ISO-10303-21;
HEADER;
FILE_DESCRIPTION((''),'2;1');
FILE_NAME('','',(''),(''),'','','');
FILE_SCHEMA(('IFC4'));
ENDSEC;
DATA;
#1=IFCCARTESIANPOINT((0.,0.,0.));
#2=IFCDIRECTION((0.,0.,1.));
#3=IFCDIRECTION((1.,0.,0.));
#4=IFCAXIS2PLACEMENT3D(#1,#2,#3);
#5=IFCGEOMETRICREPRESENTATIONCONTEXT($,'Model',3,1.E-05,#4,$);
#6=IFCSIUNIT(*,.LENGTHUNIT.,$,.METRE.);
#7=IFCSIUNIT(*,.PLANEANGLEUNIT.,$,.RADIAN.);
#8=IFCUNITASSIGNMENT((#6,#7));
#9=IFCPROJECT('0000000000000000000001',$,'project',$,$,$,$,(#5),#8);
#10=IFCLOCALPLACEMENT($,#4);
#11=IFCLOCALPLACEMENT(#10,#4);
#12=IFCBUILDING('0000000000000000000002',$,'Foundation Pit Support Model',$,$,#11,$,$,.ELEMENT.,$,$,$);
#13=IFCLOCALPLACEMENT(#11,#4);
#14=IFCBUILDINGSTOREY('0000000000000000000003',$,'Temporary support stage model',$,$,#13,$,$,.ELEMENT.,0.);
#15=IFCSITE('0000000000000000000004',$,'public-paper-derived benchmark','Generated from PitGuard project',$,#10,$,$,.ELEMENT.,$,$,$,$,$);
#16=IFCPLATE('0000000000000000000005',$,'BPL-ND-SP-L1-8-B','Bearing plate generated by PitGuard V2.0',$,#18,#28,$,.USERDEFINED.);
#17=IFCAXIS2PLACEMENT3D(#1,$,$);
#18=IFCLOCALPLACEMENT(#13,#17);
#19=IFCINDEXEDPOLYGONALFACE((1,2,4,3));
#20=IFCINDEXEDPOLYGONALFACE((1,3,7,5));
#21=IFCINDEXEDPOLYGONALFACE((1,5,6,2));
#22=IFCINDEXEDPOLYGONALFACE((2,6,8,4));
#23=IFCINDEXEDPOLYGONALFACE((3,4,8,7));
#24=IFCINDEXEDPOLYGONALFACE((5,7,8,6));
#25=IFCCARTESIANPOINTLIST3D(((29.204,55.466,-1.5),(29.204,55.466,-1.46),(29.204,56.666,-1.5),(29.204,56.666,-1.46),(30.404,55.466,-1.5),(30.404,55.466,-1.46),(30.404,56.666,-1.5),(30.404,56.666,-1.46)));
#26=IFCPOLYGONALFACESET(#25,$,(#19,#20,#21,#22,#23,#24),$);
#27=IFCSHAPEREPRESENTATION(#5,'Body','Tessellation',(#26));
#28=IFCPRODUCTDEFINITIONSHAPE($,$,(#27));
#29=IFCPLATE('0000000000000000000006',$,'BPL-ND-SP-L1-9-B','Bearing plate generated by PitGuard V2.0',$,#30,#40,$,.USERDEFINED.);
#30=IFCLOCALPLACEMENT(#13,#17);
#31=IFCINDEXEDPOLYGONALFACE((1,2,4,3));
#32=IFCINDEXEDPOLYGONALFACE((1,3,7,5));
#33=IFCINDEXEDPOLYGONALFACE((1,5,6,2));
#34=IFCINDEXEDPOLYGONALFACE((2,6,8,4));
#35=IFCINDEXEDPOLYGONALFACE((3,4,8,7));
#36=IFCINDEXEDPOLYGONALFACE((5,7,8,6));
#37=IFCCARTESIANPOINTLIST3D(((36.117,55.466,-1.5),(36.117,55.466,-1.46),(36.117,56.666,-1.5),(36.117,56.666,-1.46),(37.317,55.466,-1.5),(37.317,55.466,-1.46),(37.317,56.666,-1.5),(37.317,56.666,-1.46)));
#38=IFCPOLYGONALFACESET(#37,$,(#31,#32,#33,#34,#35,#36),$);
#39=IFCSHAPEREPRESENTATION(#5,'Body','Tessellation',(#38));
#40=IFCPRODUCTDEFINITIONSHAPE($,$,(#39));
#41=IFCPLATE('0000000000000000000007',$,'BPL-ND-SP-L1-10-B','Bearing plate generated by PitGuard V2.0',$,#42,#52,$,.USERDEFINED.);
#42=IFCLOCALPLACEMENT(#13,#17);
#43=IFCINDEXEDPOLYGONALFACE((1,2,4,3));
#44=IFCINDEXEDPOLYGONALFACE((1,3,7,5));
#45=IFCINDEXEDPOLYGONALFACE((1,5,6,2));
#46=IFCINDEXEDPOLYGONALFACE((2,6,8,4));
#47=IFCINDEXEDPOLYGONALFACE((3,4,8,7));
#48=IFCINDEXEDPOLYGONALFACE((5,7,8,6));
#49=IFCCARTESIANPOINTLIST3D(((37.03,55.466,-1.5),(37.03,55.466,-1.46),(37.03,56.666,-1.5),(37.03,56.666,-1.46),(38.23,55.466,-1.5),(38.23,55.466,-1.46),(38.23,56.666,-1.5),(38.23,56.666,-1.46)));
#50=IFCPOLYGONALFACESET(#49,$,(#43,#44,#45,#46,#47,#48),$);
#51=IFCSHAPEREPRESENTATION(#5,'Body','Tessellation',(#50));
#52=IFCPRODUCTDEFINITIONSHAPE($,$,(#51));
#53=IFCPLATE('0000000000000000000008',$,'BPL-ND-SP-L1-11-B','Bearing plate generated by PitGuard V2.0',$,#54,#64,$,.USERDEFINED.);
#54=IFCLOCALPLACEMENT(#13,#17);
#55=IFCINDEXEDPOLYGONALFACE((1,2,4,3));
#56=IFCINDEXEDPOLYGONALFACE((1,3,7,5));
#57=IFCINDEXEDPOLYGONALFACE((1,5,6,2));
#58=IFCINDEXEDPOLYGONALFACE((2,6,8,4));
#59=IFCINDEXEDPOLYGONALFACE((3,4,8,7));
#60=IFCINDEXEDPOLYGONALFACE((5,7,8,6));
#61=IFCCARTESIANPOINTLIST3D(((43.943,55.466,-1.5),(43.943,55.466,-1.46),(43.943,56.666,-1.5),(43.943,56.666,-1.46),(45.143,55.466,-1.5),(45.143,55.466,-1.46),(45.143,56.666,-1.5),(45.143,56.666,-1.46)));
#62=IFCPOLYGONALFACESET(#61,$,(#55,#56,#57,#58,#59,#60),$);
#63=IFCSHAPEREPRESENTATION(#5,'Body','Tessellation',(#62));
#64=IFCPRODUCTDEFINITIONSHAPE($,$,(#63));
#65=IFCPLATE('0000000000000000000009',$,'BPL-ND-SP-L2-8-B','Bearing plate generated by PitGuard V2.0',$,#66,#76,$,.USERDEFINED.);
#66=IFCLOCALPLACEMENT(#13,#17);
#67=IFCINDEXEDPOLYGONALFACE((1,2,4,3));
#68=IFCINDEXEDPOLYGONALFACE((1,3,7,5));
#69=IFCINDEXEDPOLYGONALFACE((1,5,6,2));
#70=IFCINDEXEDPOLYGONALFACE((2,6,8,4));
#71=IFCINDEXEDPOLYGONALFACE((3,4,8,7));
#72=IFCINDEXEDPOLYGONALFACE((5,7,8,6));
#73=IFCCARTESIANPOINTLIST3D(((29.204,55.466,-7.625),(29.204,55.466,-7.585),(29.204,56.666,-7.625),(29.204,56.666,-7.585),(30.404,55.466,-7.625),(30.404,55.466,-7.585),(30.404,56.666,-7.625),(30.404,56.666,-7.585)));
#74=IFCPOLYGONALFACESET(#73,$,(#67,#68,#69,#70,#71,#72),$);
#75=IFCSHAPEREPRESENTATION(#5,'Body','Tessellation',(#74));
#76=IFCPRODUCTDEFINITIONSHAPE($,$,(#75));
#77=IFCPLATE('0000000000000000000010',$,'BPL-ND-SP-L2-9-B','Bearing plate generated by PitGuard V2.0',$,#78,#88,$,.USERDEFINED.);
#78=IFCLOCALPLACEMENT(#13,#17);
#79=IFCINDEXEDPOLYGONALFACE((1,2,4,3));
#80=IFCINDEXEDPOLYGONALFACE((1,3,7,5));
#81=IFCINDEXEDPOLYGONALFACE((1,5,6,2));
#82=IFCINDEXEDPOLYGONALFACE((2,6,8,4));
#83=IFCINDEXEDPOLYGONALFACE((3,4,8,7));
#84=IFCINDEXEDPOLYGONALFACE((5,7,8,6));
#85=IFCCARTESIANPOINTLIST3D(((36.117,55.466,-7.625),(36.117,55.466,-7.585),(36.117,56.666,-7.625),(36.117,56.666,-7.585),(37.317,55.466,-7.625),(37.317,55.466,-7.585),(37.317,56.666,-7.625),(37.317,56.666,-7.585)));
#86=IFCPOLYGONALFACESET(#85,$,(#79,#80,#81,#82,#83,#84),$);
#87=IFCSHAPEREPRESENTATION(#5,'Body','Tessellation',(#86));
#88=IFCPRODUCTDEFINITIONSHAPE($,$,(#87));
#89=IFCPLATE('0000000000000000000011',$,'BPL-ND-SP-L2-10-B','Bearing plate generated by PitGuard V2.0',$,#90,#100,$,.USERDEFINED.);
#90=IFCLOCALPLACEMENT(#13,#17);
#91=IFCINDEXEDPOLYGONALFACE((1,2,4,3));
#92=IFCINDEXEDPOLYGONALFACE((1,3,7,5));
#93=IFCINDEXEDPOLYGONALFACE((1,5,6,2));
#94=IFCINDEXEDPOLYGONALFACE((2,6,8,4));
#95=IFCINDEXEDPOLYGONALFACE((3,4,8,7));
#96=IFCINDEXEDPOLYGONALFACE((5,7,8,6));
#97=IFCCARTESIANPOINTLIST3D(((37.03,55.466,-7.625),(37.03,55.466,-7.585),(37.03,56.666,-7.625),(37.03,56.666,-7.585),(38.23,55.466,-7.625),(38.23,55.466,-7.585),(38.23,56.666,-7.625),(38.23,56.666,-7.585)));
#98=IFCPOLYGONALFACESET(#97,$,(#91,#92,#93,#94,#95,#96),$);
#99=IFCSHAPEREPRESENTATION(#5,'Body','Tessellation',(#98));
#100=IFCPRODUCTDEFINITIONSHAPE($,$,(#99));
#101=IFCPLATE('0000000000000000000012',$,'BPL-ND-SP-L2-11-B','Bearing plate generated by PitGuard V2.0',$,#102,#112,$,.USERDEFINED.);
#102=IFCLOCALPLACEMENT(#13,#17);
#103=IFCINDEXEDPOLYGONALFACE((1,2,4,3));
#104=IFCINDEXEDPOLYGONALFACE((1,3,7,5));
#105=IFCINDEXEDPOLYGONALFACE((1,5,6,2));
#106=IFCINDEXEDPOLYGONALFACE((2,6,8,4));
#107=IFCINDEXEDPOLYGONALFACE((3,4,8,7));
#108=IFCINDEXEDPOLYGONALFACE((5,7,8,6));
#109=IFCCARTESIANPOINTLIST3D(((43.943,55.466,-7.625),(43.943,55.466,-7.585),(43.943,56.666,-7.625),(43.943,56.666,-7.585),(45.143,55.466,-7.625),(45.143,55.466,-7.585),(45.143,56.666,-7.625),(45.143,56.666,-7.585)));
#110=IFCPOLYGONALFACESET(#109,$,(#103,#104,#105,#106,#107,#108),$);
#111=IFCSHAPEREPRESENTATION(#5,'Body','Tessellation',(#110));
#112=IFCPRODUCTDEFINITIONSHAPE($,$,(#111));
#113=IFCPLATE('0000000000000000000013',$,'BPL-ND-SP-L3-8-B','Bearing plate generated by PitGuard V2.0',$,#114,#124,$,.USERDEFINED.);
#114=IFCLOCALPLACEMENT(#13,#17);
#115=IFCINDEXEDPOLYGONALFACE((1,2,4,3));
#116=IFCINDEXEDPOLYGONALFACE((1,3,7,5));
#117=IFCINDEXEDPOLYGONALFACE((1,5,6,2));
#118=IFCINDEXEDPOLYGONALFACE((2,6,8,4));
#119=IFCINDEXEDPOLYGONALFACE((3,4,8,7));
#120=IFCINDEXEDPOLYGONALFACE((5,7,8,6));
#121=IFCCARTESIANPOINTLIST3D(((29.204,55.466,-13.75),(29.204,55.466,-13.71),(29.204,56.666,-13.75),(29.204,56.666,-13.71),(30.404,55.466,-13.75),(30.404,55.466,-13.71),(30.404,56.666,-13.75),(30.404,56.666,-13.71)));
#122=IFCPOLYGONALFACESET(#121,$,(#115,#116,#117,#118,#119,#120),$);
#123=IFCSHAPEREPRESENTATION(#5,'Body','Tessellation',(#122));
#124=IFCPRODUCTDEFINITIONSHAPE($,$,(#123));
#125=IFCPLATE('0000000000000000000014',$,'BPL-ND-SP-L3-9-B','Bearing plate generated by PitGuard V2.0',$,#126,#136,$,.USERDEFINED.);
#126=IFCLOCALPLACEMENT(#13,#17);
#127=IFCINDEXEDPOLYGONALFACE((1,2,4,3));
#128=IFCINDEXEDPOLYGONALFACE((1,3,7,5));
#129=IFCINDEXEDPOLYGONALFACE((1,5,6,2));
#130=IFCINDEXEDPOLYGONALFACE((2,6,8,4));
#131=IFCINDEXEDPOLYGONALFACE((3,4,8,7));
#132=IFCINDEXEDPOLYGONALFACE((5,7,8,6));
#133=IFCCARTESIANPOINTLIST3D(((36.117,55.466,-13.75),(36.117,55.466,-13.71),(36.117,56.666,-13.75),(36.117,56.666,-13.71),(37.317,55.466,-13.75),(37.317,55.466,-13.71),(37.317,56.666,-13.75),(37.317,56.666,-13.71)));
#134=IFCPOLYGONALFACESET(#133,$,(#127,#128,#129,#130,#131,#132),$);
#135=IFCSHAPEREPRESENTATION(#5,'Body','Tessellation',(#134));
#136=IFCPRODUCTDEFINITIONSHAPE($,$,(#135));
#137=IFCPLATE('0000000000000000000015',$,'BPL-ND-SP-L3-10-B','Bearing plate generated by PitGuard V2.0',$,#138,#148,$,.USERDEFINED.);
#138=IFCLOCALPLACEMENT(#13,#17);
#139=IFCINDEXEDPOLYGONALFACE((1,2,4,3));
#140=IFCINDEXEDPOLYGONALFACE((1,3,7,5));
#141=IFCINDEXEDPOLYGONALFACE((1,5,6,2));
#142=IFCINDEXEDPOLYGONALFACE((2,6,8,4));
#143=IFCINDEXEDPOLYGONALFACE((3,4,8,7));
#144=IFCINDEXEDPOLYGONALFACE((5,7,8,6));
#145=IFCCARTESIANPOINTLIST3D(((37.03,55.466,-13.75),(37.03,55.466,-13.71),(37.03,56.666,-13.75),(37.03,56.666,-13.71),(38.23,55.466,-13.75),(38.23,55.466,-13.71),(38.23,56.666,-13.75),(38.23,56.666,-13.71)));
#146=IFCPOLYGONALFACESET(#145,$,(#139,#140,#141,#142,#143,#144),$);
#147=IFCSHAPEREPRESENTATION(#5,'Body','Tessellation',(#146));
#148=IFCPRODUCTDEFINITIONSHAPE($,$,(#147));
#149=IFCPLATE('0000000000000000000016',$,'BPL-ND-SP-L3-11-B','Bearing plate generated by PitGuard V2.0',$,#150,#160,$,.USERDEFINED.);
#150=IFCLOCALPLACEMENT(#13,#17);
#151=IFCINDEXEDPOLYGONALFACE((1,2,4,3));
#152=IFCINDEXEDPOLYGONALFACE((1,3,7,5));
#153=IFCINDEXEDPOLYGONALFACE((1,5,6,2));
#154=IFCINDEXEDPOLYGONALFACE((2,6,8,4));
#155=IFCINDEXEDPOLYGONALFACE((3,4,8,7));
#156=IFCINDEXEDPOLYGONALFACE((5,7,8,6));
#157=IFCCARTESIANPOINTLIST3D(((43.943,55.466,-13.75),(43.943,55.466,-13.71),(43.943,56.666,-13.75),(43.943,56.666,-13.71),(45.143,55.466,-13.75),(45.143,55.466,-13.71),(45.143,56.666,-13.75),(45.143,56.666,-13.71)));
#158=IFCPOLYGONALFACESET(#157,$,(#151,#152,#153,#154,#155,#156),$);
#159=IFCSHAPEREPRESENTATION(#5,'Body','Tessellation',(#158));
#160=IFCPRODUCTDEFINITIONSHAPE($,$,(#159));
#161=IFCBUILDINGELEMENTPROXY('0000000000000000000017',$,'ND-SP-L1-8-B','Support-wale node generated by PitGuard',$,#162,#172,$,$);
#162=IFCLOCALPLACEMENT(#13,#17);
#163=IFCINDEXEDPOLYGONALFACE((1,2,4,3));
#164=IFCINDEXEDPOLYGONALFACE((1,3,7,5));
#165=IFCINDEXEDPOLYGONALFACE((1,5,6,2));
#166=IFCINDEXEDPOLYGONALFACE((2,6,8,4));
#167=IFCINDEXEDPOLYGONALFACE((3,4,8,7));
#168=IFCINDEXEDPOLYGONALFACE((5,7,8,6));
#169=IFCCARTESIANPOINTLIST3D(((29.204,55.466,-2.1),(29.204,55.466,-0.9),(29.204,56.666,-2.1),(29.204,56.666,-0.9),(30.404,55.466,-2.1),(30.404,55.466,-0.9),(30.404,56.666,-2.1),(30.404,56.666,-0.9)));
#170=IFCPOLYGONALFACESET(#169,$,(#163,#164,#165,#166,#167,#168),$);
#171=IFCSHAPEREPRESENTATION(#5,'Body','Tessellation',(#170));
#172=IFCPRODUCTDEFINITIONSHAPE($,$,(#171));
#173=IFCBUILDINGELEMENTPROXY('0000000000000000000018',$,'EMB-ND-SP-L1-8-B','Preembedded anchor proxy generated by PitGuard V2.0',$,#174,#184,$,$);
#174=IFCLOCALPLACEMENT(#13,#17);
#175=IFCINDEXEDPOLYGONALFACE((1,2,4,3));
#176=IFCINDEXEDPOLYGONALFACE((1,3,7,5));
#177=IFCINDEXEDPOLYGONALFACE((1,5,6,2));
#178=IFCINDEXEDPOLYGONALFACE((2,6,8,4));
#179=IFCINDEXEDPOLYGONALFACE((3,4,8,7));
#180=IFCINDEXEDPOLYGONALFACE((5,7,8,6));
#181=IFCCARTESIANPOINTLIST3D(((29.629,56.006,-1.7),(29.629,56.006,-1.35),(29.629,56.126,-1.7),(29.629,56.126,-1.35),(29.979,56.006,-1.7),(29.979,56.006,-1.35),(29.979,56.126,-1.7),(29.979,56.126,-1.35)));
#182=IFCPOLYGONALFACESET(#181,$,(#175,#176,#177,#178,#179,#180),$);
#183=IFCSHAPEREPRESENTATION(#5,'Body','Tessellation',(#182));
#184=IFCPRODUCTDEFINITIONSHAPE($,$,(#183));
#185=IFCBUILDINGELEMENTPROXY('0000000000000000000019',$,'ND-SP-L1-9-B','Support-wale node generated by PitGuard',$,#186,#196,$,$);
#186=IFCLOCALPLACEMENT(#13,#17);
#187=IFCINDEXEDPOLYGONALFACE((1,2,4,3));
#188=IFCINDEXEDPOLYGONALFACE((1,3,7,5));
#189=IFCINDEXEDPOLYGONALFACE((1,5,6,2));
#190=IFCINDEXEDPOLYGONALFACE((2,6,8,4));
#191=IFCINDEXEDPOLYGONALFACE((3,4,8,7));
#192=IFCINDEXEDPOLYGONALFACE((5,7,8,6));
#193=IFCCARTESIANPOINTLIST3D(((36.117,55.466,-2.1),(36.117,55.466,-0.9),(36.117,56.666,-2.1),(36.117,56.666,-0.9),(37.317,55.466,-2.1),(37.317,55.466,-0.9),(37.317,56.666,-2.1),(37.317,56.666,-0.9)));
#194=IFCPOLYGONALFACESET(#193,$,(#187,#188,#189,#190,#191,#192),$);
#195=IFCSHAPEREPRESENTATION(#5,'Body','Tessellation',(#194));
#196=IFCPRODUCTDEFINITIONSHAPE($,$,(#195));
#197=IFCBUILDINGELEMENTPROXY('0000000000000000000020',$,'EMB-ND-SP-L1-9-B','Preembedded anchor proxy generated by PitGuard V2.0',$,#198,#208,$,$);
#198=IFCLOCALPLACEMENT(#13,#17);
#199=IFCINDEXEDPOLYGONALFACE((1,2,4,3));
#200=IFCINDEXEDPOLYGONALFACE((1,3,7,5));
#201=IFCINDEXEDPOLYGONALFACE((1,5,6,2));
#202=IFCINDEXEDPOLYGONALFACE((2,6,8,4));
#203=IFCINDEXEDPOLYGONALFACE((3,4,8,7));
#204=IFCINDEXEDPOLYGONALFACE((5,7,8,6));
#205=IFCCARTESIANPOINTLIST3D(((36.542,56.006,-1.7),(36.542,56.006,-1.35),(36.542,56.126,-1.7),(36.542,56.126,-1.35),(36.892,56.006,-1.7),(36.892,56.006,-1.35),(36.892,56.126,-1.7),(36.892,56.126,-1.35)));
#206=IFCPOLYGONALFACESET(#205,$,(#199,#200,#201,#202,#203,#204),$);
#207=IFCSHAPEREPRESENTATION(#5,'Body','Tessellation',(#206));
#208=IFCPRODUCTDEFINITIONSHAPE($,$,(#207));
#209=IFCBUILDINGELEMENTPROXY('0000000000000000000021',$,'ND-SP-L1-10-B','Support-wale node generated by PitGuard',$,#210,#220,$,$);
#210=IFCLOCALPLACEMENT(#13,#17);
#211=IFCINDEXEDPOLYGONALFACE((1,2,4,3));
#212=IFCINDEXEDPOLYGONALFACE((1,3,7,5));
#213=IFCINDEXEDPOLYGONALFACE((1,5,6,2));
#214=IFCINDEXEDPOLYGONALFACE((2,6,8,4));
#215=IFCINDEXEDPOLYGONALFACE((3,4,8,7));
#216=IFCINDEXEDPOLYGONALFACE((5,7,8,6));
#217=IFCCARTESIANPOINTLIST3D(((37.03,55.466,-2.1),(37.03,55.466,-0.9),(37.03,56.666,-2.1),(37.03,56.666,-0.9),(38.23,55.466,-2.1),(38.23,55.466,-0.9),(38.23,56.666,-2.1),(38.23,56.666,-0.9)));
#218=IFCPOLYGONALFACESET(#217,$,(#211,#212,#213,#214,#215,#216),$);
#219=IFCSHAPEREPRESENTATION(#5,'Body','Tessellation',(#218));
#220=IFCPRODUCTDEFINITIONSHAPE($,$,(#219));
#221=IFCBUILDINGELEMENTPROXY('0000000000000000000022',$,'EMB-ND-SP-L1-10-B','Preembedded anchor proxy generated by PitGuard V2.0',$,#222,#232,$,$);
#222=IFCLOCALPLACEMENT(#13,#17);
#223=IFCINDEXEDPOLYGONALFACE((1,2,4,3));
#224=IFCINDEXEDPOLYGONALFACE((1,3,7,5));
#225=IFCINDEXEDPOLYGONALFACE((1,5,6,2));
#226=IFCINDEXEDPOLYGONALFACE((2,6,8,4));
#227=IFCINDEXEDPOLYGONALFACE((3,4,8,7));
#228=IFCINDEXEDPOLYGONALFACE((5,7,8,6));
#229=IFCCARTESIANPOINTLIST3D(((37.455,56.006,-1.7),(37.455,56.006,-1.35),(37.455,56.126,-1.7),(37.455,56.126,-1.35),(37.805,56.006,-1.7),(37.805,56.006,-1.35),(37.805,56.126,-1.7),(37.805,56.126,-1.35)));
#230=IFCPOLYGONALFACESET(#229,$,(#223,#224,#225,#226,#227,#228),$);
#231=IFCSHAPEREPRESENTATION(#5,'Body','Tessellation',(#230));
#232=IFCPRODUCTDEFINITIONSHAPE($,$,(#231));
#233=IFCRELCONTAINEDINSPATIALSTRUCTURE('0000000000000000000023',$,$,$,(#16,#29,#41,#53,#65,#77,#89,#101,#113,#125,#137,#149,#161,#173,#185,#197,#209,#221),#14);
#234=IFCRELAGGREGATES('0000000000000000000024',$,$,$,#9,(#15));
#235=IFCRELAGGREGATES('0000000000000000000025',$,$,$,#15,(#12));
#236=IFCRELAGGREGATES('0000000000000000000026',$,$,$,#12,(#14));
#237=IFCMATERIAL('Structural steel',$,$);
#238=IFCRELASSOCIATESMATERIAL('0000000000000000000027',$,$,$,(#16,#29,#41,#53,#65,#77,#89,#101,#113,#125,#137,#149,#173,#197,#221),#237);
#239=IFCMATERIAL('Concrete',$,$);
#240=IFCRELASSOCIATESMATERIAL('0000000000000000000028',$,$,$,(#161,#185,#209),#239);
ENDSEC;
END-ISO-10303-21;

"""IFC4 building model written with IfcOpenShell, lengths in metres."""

from ifc_helpers import new_model, si_unit, frame, origin_with_axes, origin_2d, place, context, project, spatial, rectangle, extrude, material, element, save


model = new_model("IFC4")

# Units and contexts
model_context = context("Model", 3, precision=1e-05, world=origin_with_axes())
ifc_project = project(units=[si_unit("LENGTHUNIT", "METRE"), si_unit("PLANEANGLEUNIT", "RADIAN")], contexts=[model_context])

# Site, building, storey
site_placement = place(None, origin_with_axes())
site = spatial("IfcSite", under=ifc_project, at=site_placement, Name="public-paper-derived benchmark", Description="Generated from PitGuard project", CompositionType="ELEMENT")
building_placement = place(site_placement, origin_with_axes())
building = spatial("IfcBuilding", under=site, at=building_placement, Name="Foundation Pit Support Model", CompositionType="ELEMENT")
storey_placement = place(building_placement, origin_with_axes())
storey = spatial("IfcBuildingStorey", under=building, at=storey_placement, Name="Temporary support stage model", CompositionType="ELEMENT", Elevation=0.0)

# Plates
ifc_material_1 = material(Name="Structural steel")
for number, where, z_axis, x_axis, name in (
    (1, (29.804, 56.066, -1.5), (0.0, 0.0, 1.0), (1.0, 0.0, 0.0), "BPL-ND-SP-L1-8-B"),
    (2, (36.717, 56.066, -1.5), (0.0, 0.0, 1.0), (1.0, 0.0, 0.0), "BPL-ND-SP-L1-9-B"),
    (3, (37.63, 56.066, -1.5), (0.0, 0.0, 1.0), (1.0, 0.0, 0.0), "BPL-ND-SP-L1-10-B"),
    (4, (44.543, 56.066, -1.5), (0.0, 0.0, 1.0), (1.0, 0.0, 0.0), "BPL-ND-SP-L1-11-B"),
    (5, (29.804, 56.066, -7.625), (0.0, 0.0, 1.0), (1.0, 0.0, 0.0), "BPL-ND-SP-L2-8-B"),
    (6, (36.717, 56.066, -7.625), (0.0, 0.0, 1.0), (1.0, 0.0, 0.0), "BPL-ND-SP-L2-9-B"),
    (7, (37.63, 56.066, -7.625), (0.0, 0.0, 1.0), (1.0, 0.0, 0.0), "BPL-ND-SP-L2-10-B"),
    (8, (44.543, 56.066, -7.625), (0.0, 0.0, 1.0), (1.0, 0.0, 0.0), "BPL-ND-SP-L2-11-B"),
    (9, (29.804, 56.066, -13.75), (0.0, 0.0, 1.0), (1.0, 0.0, 0.0), "BPL-ND-SP-L3-8-B"),
    (10, (36.717, 56.066, -13.75), (0.0, 0.0, 1.0), (1.0, 0.0, 0.0), "BPL-ND-SP-L3-9-B"),
    (11, (37.63, 56.066, -13.75), (0.0, 0.0, 1.0), (1.0, 0.0, 0.0), "BPL-ND-SP-L3-10-B"),
    (12, (44.543, 56.066, -13.75), (0.0, 0.0, 1.0), (1.0, 0.0, 0.0), "BPL-ND-SP-L3-11-B"),
):
    element("IfcPlate", number, at=place(storey_placement, frame(where, z_axis=z_axis, x_axis=x_axis)), inside=storey, material=ifc_material_1, Name=name, Description="Bearing plate generated by PitGuard V2.0", PredefinedType="USERDEFINED", context=model_context, shape_type="SweptSolid", body=[
        extrude(rectangle(XDim=1.2, YDim=1.2, at=origin_2d()), origin_with_axes(), (0.0, 0.0, 1.0), 0.04),
    ])

# Building element proxies
ifc_material_2 = material(Name="Concrete")
proxy_1_placement = place(storey_placement, frame((29.804, 56.066, -2.1), z_axis=(0.0, 0.0, 1.0), x_axis=(1.0, 0.0, 0.0)))
element("IfcBuildingElementProxy", 13, at=proxy_1_placement, inside=storey, material=ifc_material_2, Name="ND-SP-L1-8-B", Description="Support-wale node generated by PitGuard", context=model_context, shape_type="SweptSolid", body=[
    extrude(rectangle(XDim=1.2, YDim=1.2, at=origin_2d()), origin_with_axes(), (0.0, 0.0, 1.0), 1.2),
])
proxy_2_placement = place(storey_placement, frame((29.804, 56.066, -1.7), z_axis=(0.0, 0.0, 1.0), x_axis=(1.0, 0.0, 0.0)))
element("IfcBuildingElementProxy", 14, at=proxy_2_placement, inside=storey, material=ifc_material_1, Name="EMB-ND-SP-L1-8-B", Description="Preembedded anchor proxy generated by PitGuard V2.0", context=model_context, shape_type="SweptSolid", body=[
    extrude(rectangle(XDim=0.35, YDim=0.12, at=origin_2d()), origin_with_axes(), (0.0, 0.0, 1.0), 0.35),
])
proxy_3_placement = place(storey_placement, frame((36.717, 56.066, -2.1), z_axis=(0.0, 0.0, 1.0), x_axis=(1.0, 0.0, 0.0)))
element("IfcBuildingElementProxy", 15, at=proxy_3_placement, inside=storey, material=ifc_material_2, Name="ND-SP-L1-9-B", Description="Support-wale node generated by PitGuard", context=model_context, shape_type="SweptSolid", body=[
    extrude(rectangle(XDim=1.2, YDim=1.2, at=origin_2d()), origin_with_axes(), (0.0, 0.0, 1.0), 1.2),
])
proxy_4_placement = place(storey_placement, frame((36.717, 56.066, -1.7), z_axis=(0.0, 0.0, 1.0), x_axis=(1.0, 0.0, 0.0)))
element("IfcBuildingElementProxy", 16, at=proxy_4_placement, inside=storey, material=ifc_material_1, Name="EMB-ND-SP-L1-9-B", Description="Preembedded anchor proxy generated by PitGuard V2.0", context=model_context, shape_type="SweptSolid", body=[
    extrude(rectangle(XDim=0.35, YDim=0.12, at=origin_2d()), origin_with_axes(), (0.0, 0.0, 1.0), 0.35),
])
proxy_5_placement = place(storey_placement, frame((37.63, 56.066, -2.1), z_axis=(0.0, 0.0, 1.0), x_axis=(1.0, 0.0, 0.0)))
element("IfcBuildingElementProxy", 17, at=proxy_5_placement, inside=storey, material=ifc_material_2, Name="ND-SP-L1-10-B", Description="Support-wale node generated by PitGuard", context=model_context, shape_type="SweptSolid", body=[
    extrude(rectangle(XDim=1.2, YDim=1.2, at=origin_2d()), origin_with_axes(), (0.0, 0.0, 1.0), 1.2),
])
proxy_6_placement = place(storey_placement, frame((37.63, 56.066, -1.7), z_axis=(0.0, 0.0, 1.0), x_axis=(1.0, 0.0, 0.0)))
element("IfcBuildingElementProxy", 18, at=proxy_6_placement, inside=storey, material=ifc_material_1, Name="EMB-ND-SP-L1-10-B", Description="Preembedded anchor proxy generated by PitGuard V2.0", context=model_context, shape_type="SweptSolid", body=[
    extrude(rectangle(XDim=0.35, YDim=0.12, at=origin_2d()), origin_with_axes(), (0.0, 0.0, 1.0), 0.35),
])

save(model, "model.ifc")
